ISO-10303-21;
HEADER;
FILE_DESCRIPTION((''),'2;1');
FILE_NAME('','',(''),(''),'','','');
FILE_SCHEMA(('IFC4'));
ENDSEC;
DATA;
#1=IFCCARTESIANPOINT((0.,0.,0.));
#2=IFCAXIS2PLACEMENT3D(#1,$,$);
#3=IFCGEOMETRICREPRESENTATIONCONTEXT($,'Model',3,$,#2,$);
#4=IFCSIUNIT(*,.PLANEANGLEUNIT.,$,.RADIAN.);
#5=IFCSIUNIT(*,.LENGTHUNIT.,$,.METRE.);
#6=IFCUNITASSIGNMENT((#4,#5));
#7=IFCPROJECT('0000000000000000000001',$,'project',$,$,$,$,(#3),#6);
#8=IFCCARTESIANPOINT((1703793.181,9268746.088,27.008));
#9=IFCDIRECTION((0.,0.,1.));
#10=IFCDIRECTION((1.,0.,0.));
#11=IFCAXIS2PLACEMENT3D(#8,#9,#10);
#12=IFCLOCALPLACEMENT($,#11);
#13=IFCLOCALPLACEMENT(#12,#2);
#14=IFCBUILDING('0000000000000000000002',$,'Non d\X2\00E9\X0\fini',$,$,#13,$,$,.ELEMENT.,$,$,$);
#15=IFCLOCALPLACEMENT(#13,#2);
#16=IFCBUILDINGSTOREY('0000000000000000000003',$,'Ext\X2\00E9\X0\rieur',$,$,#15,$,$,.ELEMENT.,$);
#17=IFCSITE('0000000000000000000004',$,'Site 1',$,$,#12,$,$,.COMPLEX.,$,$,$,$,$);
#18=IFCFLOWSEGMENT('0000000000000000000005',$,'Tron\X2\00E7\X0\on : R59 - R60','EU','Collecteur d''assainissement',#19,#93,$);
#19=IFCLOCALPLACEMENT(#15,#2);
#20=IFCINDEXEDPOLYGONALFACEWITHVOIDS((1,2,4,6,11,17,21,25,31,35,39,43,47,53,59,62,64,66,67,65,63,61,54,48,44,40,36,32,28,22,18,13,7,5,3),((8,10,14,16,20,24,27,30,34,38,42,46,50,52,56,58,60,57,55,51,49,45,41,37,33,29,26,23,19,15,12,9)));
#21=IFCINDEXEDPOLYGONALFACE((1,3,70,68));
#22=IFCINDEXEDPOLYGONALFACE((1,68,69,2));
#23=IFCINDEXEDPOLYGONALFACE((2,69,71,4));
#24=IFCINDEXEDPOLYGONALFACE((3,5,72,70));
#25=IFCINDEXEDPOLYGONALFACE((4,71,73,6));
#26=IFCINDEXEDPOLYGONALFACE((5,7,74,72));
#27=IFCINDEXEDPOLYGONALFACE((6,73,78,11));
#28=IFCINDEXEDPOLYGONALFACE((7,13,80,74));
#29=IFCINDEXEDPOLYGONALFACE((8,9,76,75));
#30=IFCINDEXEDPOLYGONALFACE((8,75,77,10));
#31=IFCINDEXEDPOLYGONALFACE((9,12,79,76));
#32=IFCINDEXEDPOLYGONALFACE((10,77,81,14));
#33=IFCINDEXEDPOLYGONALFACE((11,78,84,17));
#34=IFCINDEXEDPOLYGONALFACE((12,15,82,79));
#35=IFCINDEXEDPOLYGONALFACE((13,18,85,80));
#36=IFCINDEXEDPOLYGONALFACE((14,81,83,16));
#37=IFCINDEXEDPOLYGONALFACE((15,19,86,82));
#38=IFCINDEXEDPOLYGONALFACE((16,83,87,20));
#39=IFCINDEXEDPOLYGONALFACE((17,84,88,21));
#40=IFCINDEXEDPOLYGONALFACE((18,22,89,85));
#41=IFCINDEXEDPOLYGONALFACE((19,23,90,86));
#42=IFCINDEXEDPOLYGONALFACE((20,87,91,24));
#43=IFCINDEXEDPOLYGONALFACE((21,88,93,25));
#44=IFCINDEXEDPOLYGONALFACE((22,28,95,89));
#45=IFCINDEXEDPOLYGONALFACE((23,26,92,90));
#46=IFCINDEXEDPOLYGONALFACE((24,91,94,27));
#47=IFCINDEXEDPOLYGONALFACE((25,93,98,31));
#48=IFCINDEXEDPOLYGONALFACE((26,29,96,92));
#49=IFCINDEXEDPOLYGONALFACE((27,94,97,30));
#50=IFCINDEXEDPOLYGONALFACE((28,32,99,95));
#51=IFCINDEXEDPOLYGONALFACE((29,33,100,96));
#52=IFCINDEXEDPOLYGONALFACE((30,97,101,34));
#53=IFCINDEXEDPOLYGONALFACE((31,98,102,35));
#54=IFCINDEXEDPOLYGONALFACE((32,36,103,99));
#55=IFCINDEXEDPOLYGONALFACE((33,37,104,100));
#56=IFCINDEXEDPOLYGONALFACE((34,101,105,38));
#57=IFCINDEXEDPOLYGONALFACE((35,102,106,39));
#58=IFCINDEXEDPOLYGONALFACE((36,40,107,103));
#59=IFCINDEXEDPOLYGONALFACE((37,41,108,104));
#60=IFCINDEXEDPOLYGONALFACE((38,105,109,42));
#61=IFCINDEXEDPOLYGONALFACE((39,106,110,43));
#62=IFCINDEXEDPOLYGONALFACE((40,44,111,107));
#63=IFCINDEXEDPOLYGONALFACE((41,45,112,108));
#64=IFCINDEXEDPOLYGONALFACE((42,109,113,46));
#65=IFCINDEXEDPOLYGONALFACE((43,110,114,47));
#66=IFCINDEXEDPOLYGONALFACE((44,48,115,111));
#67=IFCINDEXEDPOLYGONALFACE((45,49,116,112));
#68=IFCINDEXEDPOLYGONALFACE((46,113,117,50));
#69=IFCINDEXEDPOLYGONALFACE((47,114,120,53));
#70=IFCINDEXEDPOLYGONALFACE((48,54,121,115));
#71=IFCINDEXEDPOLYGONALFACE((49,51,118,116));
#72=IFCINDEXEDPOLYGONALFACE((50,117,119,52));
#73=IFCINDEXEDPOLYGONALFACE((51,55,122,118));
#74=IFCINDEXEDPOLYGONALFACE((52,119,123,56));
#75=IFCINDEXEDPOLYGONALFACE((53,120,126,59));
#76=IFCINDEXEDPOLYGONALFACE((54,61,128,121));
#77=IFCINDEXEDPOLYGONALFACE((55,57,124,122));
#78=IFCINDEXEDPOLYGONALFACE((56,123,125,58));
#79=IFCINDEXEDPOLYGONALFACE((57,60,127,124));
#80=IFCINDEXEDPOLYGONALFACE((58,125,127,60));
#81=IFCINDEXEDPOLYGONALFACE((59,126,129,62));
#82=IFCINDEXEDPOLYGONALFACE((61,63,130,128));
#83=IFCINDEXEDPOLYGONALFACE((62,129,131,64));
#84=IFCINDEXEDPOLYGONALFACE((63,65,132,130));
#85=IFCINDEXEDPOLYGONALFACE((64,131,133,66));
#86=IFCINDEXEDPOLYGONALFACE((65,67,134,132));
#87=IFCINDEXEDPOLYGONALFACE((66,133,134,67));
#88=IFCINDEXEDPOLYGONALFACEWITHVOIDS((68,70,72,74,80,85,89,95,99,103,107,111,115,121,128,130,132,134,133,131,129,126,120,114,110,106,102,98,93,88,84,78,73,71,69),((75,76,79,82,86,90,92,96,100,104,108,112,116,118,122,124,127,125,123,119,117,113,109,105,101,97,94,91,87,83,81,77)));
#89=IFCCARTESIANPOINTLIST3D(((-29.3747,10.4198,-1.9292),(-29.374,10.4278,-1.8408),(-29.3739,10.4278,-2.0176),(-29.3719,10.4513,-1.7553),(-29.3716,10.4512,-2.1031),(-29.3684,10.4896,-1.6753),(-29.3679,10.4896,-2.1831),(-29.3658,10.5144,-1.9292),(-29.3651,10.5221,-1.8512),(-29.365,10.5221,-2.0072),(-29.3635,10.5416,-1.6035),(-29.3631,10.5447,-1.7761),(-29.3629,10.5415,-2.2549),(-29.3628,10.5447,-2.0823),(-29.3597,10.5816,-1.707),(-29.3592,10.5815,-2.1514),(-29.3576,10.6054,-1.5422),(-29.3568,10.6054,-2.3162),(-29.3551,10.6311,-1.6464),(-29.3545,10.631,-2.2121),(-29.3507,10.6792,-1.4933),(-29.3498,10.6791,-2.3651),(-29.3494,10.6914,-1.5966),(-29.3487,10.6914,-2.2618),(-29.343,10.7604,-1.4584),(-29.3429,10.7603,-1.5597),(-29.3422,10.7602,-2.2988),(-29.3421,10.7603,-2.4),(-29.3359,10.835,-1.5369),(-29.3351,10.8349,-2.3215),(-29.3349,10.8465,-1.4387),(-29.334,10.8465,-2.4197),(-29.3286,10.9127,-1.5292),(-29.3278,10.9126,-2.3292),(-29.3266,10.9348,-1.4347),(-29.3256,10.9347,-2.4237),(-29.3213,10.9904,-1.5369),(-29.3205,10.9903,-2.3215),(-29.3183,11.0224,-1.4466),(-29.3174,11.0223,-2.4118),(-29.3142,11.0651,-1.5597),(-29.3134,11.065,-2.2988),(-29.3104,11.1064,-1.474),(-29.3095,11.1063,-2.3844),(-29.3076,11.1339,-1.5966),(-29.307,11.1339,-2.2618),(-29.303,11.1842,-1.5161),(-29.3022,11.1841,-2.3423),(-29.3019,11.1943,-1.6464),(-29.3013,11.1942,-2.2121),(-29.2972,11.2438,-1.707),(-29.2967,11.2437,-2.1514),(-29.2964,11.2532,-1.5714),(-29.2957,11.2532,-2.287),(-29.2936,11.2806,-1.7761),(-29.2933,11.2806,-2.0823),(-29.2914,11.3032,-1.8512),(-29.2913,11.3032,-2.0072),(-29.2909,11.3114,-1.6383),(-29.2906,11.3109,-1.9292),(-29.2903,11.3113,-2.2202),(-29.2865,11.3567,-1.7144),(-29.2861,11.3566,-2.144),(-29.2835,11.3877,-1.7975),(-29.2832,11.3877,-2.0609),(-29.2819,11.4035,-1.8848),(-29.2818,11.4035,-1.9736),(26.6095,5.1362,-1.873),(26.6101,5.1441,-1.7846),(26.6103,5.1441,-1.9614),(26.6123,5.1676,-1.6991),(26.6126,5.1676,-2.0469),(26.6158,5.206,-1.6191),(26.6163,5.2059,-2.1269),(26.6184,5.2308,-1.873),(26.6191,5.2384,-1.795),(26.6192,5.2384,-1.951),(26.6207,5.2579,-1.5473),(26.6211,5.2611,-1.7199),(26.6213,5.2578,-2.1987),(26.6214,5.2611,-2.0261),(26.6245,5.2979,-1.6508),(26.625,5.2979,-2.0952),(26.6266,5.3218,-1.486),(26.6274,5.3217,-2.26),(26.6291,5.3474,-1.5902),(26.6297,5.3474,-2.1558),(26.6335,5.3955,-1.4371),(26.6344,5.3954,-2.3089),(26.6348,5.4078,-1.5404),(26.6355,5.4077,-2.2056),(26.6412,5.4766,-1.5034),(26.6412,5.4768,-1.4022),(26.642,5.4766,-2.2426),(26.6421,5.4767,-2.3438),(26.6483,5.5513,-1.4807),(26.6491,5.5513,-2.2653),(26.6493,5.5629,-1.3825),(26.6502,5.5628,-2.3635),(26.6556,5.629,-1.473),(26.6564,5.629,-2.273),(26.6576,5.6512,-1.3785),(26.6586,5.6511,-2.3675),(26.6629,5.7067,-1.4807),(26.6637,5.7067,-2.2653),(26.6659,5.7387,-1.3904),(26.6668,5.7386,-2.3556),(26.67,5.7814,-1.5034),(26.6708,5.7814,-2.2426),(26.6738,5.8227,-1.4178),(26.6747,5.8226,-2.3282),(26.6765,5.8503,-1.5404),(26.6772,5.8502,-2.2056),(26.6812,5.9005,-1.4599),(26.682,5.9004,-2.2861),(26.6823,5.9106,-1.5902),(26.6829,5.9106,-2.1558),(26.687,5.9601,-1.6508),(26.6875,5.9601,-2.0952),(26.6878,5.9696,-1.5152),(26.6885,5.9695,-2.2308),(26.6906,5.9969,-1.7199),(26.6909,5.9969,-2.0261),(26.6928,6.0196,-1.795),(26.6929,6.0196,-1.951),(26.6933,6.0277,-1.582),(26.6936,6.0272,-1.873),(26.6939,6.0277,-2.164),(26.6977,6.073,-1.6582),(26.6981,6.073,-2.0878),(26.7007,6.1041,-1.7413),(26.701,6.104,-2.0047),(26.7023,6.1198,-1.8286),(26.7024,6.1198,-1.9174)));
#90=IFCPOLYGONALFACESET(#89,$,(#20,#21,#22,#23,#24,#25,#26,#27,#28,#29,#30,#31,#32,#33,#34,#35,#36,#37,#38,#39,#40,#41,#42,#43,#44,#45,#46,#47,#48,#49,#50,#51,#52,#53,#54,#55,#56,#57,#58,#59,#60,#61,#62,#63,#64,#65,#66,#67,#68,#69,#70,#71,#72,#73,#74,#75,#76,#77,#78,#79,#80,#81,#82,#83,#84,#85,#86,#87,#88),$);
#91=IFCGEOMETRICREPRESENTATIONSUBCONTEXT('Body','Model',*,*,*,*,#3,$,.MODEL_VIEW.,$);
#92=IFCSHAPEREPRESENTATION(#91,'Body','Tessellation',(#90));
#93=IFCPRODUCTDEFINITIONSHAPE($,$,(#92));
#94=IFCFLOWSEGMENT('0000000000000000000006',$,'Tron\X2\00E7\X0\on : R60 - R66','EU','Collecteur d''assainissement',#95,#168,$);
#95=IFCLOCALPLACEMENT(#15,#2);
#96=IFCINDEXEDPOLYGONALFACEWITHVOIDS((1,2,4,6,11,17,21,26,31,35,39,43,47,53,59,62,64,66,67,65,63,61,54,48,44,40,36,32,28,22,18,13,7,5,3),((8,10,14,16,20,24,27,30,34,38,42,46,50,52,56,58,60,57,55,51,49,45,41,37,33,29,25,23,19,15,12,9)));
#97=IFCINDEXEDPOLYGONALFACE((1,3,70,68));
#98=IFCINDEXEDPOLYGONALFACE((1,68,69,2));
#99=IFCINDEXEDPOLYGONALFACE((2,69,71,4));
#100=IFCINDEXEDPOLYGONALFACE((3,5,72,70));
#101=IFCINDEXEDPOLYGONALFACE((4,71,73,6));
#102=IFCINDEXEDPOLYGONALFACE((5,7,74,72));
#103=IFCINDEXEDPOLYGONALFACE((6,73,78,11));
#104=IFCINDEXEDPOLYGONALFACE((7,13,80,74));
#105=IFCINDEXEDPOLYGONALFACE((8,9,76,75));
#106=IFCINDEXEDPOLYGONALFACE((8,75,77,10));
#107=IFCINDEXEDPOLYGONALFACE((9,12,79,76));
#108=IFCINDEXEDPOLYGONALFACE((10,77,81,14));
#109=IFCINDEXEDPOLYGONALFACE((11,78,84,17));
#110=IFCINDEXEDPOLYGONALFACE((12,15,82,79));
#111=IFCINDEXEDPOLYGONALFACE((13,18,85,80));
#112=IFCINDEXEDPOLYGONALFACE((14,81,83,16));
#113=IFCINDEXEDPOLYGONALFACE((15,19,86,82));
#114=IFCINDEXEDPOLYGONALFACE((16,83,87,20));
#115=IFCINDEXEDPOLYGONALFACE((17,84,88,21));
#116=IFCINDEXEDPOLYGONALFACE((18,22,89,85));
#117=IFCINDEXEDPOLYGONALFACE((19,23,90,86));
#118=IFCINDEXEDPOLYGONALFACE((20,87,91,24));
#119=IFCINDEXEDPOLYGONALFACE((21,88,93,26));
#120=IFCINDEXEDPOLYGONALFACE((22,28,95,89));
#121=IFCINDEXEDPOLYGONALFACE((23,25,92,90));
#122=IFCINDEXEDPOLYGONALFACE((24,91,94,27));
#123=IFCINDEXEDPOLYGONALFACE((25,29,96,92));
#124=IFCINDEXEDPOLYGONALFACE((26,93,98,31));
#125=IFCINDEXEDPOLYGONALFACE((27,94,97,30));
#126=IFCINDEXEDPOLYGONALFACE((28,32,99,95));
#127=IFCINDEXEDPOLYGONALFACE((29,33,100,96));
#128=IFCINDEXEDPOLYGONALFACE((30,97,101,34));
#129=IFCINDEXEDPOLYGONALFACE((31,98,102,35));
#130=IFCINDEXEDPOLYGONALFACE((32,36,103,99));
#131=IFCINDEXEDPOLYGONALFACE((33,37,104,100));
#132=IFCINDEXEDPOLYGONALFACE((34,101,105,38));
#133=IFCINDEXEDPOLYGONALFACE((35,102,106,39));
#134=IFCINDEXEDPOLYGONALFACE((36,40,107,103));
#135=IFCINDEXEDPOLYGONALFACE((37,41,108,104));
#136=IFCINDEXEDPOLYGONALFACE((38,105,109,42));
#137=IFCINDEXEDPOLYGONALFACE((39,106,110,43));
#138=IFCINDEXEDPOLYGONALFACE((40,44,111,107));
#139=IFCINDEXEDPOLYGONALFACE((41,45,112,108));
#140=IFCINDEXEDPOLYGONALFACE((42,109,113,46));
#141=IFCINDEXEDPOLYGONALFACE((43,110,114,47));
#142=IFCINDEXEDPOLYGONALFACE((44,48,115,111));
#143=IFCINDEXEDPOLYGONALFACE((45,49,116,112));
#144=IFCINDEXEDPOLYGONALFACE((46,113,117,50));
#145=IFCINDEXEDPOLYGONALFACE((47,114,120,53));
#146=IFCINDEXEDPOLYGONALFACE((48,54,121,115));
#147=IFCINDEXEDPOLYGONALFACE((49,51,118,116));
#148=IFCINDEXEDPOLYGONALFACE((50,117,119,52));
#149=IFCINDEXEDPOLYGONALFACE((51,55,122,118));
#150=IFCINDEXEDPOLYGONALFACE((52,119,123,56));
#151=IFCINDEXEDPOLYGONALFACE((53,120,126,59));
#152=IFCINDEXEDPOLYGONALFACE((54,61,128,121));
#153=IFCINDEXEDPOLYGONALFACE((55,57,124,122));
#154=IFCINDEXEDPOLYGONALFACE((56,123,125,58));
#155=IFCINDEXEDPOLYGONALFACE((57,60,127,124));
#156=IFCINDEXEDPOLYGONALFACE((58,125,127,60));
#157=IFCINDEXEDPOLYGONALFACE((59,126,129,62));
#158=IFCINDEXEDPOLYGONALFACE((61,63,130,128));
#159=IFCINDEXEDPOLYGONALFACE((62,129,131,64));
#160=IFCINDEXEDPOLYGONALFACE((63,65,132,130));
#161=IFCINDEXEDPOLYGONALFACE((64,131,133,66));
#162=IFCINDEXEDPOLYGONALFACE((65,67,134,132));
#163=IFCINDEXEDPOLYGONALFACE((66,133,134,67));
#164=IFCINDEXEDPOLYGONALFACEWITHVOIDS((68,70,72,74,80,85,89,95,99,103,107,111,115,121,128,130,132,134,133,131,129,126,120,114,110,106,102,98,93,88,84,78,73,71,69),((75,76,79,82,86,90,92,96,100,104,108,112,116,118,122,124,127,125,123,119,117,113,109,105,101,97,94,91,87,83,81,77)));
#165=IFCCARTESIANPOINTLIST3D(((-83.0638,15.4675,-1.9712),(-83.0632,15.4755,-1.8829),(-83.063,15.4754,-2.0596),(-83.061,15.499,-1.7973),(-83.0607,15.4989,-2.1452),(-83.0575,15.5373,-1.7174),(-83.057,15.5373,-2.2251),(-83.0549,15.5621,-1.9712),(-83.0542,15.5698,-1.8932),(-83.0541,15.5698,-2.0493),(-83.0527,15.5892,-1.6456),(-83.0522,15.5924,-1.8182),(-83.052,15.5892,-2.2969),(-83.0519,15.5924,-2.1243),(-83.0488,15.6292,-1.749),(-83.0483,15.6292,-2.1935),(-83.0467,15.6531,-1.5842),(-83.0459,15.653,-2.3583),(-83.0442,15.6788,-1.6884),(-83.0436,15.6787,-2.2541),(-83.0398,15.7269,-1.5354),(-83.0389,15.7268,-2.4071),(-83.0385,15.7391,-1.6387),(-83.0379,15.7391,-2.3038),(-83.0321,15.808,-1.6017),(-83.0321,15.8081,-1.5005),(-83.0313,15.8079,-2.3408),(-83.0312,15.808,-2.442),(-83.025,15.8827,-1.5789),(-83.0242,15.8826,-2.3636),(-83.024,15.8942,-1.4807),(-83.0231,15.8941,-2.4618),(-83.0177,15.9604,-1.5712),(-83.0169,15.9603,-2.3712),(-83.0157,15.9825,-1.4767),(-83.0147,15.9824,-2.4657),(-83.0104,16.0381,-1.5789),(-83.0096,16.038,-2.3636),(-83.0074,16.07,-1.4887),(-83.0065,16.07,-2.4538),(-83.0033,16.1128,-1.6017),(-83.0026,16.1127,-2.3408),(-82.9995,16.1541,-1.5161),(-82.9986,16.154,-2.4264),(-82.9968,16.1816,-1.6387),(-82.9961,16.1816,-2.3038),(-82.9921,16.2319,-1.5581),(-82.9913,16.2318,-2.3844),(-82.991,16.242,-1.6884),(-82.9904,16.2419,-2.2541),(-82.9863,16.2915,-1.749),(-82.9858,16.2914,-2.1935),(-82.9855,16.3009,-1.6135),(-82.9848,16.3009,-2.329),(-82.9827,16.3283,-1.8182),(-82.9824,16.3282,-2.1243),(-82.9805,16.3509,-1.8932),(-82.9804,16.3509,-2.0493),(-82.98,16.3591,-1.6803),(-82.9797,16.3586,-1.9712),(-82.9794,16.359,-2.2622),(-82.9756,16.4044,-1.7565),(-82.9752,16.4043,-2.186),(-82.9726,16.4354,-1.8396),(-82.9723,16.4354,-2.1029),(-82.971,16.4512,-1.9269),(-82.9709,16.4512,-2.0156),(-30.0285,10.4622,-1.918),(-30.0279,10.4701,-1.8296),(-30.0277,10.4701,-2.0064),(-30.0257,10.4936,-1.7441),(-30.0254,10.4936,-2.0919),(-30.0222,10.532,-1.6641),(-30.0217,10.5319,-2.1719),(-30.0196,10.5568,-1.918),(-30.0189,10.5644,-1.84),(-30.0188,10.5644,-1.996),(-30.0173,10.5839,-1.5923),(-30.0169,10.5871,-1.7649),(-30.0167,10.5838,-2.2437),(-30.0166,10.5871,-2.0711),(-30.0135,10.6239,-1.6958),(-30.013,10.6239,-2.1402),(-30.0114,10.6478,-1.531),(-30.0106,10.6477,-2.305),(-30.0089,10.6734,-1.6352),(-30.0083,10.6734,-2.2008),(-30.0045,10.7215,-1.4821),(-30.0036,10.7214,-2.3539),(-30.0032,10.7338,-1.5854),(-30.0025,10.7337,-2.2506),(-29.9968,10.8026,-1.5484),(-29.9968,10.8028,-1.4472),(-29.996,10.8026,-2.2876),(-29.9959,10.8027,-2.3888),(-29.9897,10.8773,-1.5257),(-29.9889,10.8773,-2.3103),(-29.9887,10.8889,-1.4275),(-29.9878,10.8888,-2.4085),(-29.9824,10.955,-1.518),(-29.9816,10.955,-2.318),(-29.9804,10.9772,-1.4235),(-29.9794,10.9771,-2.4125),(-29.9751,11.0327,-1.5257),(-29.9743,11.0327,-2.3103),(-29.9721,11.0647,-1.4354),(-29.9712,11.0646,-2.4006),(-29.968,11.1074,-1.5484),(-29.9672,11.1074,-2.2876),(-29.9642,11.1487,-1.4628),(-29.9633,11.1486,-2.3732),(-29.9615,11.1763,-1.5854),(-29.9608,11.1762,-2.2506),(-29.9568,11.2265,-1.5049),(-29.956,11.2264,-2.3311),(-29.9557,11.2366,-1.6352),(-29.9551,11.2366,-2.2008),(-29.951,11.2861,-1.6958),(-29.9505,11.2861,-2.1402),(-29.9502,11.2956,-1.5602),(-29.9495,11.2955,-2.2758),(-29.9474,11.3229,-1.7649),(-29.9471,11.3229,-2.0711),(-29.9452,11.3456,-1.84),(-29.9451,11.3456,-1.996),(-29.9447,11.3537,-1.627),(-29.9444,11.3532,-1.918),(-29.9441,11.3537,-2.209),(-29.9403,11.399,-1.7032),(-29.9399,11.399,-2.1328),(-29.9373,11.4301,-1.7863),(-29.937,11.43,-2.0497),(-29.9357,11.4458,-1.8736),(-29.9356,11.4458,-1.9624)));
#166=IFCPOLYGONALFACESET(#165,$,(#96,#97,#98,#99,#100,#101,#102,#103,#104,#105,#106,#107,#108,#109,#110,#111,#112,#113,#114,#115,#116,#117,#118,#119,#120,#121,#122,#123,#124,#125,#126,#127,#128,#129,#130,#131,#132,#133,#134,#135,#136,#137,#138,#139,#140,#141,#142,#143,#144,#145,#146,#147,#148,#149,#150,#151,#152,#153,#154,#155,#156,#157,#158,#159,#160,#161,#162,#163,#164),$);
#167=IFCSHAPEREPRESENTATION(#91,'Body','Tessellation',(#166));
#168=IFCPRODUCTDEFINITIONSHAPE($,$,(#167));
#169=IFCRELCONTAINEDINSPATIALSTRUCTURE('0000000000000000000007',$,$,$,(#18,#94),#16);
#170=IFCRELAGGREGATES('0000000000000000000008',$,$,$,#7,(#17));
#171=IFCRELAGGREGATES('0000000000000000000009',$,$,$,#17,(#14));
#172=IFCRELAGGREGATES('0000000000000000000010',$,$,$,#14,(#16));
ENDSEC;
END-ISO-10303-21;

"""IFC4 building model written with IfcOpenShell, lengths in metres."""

from ifc_helpers import new_model, si_unit, frame, origin, origin_2d, place, context, subcontext, project, spatial, hollow_circle, extrude, element, save


model = new_model("IFC4")

# Units and contexts
model_context = context("Model", 3, world=origin())
body_context = subcontext(model_context, "Body", "Model", "MODEL_VIEW")
ifc_project = project(units=[si_unit("PLANEANGLEUNIT", "RADIAN"), si_unit("LENGTHUNIT", "METRE")], contexts=[model_context])

# Site, building, storey
site_placement = place(None, frame((1703793.181, 9268746.088, 27.008), z_axis=(0.0, 0.0, 1.0), x_axis=(1.0, 0.0, 0.0)))
site = spatial("IfcSite", under=ifc_project, at=site_placement, Name="Site 1", CompositionType="COMPLEX")
building_placement = place(site_placement, origin())
building = spatial("IfcBuilding", under=site, at=building_placement, Name="Non défini", CompositionType="ELEMENT")
storey_placement = place(building_placement, origin())
storey = spatial("IfcBuildingStorey", under=building, at=storey_placement, Name="Extérieur", CompositionType="ELEMENT")

# Flow segments
flow_segment_1_placement = place(storey_placement, origin())
element("IfcFlowSegment", 1, at=flow_segment_1_placement, inside=storey, Name="Tronçon : R59 - R60", Description="EU", ObjectType="Collecteur d'assainissement", context=body_context, shape_type="SweptSolid", body=[
    extrude(hollow_circle(Radius=0.495, WallThickness=0.095, at=origin_2d()), frame((26.656, 5.629, -1.873), z_axis=(-0.996, 0.094, -0.001), x_axis=(-0.094, -0.996, 0.0)), (0.0, 0.0, 1.0), 56.233),
])
flow_segment_2_placement = place(storey_placement, origin())
element("IfcFlowSegment", 2, at=flow_segment_2_placement, inside=storey, Name="Tronçon : R60 - R66", Description="EU", ObjectType="Collecteur d'assainissement", context=body_context, shape_type="SweptSolid", body=[
    extrude(hollow_circle(Radius=0.495, WallThickness=0.095, at=origin_2d()), frame((-29.982, 10.955, -1.918), z_axis=(-0.996, 0.094, -0.001), x_axis=(-0.094, -0.996, 0.0)), (0.0, 0.0, 1.0), 53.271),
])

save(model, "model.ifc")
